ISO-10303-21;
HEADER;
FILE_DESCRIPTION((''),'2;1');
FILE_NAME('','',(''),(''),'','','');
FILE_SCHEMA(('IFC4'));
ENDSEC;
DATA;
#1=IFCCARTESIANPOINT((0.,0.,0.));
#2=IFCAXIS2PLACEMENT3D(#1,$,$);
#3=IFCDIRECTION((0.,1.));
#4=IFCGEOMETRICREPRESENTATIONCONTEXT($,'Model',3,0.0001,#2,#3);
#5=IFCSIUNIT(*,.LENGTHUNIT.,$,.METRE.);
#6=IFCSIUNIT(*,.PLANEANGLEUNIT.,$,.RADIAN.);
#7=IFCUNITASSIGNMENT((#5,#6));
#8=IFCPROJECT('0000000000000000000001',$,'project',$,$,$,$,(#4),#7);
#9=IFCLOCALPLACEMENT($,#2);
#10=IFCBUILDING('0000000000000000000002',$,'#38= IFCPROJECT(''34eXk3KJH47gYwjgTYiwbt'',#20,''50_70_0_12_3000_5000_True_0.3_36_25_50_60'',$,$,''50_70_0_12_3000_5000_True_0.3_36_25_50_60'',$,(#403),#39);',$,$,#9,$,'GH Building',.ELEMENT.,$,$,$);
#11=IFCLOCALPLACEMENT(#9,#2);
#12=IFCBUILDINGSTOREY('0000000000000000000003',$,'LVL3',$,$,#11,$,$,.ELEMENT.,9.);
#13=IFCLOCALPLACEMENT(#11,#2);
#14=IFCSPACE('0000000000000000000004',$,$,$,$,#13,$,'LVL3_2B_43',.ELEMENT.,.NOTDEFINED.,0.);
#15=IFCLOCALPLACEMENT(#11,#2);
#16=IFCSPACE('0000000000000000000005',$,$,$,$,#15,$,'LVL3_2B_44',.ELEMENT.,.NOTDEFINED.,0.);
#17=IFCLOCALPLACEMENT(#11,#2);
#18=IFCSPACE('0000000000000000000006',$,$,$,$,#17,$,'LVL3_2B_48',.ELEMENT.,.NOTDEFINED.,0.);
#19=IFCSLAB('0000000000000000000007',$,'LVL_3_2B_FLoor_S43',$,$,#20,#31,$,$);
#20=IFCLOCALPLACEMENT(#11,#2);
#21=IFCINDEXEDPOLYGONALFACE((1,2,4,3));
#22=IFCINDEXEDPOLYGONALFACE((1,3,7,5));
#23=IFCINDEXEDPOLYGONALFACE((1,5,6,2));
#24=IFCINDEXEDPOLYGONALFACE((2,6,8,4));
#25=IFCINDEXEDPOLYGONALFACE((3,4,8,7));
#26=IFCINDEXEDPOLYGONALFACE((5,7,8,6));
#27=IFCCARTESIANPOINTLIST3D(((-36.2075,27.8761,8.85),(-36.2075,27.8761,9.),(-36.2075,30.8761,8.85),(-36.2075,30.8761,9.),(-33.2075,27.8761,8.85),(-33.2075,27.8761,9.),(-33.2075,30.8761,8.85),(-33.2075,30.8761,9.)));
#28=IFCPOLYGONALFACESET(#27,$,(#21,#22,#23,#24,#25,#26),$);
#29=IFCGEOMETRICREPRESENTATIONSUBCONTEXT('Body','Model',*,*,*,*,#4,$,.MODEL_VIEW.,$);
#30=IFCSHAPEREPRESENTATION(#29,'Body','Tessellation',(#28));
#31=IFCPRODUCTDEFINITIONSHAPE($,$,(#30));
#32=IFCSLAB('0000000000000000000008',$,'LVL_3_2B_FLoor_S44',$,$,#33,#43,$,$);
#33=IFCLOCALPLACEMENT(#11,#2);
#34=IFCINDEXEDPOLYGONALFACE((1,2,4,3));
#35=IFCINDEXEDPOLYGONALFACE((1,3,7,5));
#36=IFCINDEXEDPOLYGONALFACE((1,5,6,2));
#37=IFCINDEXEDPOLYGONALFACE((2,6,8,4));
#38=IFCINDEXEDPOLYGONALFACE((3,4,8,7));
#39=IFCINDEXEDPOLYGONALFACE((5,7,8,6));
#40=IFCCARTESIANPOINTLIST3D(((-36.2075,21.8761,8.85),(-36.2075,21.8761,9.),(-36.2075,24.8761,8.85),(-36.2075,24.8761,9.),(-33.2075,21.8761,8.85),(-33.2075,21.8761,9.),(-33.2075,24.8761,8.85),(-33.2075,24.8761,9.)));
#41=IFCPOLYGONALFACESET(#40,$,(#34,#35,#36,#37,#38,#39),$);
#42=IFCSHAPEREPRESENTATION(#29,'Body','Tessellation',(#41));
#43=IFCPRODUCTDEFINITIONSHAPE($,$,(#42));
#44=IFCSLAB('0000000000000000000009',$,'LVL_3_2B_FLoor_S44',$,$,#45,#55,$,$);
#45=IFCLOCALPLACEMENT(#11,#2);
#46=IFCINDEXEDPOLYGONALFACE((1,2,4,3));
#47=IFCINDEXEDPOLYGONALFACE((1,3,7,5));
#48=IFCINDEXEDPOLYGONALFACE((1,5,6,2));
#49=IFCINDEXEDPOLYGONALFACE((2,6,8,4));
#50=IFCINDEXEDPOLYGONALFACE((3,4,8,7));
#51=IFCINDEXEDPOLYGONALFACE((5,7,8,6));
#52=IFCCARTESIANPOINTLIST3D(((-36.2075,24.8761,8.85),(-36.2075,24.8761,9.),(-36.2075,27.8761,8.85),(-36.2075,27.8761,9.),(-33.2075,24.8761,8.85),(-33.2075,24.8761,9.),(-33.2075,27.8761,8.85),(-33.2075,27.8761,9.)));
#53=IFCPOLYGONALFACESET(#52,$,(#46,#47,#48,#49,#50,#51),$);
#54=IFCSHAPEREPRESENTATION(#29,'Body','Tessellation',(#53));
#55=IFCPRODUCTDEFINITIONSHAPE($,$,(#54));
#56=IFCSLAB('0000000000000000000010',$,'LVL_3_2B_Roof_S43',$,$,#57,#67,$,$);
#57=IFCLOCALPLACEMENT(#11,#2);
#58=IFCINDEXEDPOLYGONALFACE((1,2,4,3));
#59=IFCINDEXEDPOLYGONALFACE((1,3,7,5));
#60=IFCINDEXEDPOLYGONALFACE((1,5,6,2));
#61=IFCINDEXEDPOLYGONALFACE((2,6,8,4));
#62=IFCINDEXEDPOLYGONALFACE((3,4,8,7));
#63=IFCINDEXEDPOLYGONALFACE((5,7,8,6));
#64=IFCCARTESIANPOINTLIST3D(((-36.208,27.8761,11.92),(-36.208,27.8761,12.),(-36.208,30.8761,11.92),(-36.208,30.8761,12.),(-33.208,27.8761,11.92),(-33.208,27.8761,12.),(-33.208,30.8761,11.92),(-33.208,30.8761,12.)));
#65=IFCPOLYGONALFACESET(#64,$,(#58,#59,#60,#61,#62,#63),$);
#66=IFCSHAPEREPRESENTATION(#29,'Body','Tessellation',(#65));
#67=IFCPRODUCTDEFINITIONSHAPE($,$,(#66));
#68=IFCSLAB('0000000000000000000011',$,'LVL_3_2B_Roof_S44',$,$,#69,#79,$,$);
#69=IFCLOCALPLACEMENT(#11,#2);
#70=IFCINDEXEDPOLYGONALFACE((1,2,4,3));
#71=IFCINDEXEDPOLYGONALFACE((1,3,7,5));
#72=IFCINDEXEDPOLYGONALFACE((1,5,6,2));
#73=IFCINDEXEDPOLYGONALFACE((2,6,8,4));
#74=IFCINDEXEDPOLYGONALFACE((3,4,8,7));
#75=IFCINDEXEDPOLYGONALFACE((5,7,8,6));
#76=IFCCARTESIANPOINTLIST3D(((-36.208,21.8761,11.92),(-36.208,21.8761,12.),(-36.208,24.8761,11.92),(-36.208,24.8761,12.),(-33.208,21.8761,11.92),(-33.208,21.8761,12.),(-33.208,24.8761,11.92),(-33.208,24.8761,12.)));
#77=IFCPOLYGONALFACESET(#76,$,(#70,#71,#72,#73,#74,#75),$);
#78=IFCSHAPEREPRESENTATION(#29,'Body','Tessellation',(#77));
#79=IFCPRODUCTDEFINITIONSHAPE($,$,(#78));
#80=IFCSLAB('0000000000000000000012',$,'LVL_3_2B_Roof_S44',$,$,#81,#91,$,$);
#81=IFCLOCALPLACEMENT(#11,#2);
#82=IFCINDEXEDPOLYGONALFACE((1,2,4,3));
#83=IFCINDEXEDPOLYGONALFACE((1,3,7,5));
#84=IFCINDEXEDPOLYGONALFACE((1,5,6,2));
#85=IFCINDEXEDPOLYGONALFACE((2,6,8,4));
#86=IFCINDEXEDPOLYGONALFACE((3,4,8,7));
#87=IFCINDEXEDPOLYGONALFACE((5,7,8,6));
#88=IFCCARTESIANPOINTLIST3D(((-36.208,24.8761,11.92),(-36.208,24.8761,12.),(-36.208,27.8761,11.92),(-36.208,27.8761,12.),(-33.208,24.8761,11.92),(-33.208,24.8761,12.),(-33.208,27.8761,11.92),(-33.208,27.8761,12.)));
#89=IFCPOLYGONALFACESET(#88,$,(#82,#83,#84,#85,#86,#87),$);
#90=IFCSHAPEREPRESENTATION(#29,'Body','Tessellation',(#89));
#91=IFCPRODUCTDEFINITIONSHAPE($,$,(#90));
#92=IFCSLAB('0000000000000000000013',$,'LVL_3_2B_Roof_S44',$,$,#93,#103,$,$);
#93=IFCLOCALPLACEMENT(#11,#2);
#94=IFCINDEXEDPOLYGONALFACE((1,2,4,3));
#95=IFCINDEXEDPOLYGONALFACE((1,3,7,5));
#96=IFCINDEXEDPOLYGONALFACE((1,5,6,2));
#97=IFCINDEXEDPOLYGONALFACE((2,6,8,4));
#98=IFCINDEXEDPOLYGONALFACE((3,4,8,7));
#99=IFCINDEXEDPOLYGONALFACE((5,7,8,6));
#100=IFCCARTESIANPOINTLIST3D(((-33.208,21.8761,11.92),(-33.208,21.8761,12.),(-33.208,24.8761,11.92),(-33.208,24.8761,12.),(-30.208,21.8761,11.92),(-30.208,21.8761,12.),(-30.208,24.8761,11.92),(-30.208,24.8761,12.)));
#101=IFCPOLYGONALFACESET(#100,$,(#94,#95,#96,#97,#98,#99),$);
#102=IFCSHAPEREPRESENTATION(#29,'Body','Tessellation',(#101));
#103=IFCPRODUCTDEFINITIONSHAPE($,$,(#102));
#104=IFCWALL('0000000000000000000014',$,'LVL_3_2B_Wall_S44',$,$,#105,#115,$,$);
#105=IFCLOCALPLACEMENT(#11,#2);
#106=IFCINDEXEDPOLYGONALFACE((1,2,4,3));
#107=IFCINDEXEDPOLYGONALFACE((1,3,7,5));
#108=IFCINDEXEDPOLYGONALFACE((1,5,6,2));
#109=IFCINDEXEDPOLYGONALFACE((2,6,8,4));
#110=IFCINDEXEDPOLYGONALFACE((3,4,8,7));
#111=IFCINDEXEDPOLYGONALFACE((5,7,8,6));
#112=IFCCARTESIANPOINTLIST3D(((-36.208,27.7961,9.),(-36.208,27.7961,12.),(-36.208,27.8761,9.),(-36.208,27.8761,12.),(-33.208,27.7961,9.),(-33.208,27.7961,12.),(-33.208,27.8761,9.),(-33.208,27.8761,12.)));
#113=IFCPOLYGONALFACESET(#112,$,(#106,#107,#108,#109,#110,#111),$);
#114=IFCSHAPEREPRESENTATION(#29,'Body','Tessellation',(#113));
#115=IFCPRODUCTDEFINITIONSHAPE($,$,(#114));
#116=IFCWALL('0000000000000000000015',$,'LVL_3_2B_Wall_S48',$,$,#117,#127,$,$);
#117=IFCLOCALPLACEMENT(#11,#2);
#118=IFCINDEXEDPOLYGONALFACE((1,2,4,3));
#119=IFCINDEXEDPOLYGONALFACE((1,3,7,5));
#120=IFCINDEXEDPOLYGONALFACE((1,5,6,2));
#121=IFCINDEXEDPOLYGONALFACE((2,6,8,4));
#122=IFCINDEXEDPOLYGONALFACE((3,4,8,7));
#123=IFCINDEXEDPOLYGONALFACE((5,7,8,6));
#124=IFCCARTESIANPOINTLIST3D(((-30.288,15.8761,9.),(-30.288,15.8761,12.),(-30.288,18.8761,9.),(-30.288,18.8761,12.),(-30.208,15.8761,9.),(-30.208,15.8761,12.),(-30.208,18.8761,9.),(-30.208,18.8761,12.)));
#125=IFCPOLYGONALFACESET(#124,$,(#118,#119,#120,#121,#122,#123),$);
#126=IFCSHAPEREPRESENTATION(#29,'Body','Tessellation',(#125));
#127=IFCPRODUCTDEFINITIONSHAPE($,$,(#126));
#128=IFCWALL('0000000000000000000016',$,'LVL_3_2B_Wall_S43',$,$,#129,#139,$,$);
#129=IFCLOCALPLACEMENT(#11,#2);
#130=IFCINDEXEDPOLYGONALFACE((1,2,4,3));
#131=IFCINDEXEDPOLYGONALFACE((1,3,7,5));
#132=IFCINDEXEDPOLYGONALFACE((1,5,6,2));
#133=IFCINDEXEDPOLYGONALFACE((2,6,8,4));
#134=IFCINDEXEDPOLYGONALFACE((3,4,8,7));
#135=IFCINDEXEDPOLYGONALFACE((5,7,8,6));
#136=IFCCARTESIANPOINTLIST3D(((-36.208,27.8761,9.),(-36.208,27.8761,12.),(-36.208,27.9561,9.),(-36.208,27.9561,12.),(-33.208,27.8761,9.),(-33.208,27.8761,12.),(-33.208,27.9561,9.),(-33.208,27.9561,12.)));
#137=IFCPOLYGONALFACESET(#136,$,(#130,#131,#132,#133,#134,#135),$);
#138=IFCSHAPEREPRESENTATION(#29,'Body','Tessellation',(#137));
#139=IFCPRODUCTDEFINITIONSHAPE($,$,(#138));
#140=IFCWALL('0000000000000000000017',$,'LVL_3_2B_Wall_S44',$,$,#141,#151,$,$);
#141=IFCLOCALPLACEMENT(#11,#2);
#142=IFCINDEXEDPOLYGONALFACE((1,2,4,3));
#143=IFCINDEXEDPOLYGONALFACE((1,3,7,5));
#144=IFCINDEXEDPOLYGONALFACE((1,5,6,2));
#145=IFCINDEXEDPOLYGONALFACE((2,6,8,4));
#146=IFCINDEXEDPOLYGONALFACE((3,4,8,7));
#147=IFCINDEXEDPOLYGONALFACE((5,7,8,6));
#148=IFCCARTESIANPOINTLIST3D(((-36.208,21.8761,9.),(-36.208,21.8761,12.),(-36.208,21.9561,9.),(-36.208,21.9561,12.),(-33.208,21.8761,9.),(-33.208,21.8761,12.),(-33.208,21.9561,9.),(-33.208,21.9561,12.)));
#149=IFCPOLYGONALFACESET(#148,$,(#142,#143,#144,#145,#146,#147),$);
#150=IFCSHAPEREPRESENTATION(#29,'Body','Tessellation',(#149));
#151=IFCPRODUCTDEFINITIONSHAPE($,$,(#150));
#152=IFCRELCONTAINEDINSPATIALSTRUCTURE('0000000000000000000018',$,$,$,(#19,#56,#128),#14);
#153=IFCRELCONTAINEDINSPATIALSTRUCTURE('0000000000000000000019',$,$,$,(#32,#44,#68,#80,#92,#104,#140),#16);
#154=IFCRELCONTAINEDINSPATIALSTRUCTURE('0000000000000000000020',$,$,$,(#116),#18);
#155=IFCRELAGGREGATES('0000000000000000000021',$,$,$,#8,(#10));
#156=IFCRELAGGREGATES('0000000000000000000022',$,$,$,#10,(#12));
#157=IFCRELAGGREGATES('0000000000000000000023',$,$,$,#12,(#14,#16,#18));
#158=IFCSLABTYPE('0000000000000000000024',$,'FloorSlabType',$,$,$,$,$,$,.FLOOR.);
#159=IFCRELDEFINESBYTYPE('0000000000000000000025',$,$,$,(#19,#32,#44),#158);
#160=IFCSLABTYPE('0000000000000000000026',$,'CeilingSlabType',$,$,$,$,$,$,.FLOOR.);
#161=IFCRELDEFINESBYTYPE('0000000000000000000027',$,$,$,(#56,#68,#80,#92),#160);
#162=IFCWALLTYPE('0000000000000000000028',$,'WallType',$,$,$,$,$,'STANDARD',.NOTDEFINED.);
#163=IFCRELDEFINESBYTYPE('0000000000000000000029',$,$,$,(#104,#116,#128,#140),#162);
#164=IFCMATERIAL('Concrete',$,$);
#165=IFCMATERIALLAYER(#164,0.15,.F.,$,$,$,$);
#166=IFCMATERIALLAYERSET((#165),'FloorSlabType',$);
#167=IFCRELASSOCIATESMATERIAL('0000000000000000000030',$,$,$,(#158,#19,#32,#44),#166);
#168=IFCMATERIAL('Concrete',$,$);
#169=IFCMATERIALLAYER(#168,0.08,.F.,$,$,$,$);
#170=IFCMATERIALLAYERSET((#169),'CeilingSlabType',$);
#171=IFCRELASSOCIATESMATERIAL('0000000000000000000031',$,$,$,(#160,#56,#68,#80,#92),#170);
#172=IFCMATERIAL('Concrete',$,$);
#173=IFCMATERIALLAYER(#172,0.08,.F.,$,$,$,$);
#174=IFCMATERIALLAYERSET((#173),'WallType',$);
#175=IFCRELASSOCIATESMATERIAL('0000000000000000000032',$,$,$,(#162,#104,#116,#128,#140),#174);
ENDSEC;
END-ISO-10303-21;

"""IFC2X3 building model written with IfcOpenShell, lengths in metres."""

from ifc_helpers import new_model, si_unit, direction, frame, frame_2d, origin, place, context, subcontext, project, spatial, rectangle, extrude, material, layer, layer_set, layer_usage, type_object, element, save


model = new_model("IFC2X3")

# Units and contexts
model_context = context("Model", 3, precision=0.0001, world=origin(), true_north=direction((0.0, 1.0)))
body_context = subcontext(model_context, "Body", "Model", "MODEL_VIEW")
ifc_project = project(units=[si_unit("LENGTHUNIT", "METRE"), si_unit("PLANEANGLEUNIT", "RADIAN")], contexts=[model_context])

# Building, storey, space
building_placement = place(None, origin())
building = spatial("IfcBuilding", under=ifc_project, at=building_placement, Name="#38= IFCPROJECT('34eXk3KJH47gYwjgTYiwbt',#20,'50_70_0_12_3000_5000_True_0.3_36_25_50_60',$,$,'50_70_0_12_3000_5000_True_0.3_36_25_50_60',$,(#403),#39);", LongName="GH Building", CompositionType="ELEMENT")
storey_placement = place(building_placement, origin())
storey = spatial("IfcBuildingStorey", under=building, at=storey_placement, Name="LVL3", CompositionType="ELEMENT", Elevation=9.0)
space_1_placement = place(storey_placement, origin())
space_1 = spatial("IfcSpace", under=storey, at=space_1_placement, LongName="LVL3_2B_43", CompositionType="ELEMENT", InteriorOrExteriorSpace="NOTDEFINED", ElevationWithFlooring=0.0)

# Slab
ifc_material_1 = material(Name="Concrete")
ifc_layer_1 = layer(ifc_material_1, 0.15, ventilated=False)
ifc_layer_set_1 = layer_set([ifc_layer_1], Name="FloorSlabType")
ifc_layer_usage_1 = layer_usage(ifc_layer_set_1, "AXIS3", "NEGATIVE", -0.15)
slab_type_1 = type_object("IfcSlabType", Name="FloorSlabType", PredefinedType="FLOOR", material=ifc_layer_set_1)
slab_1_placement = place(space_1_placement, frame((-33.2075, 27.8761, 8.85), z_axis=(0.0, 0.0, 1.0), x_axis=(0.0, 1.0, 0.0)))
element("IfcSlab", 1, at=slab_1_placement, inside=space_1, type_object=slab_type_1, material=ifc_layer_usage_1, Name="LVL_3_2B_FLoor_S43", context=body_context, shape_type="SweptSolid", body=[
    extrude(rectangle(XDim=3.0, YDim=3.0, at=frame_2d((1.5, 1.5))), origin(), (0.0, 0.0, 1.0), 0.15),
])

# Shared definitions
space_2_placement = place(storey_placement, origin())
space_2 = spatial("IfcSpace", under=storey, at=space_2_placement, LongName="LVL3_2B_44", CompositionType="ELEMENT", InteriorOrExteriorSpace="NOTDEFINED", ElevationWithFlooring=0.0)

# Slabs
ifc_layer_usage_2 = layer_usage(ifc_layer_set_1, "AXIS3", "NEGATIVE", -0.15)
slab_2_placement = place(space_2_placement, frame((-33.2075, 21.8761, 8.85), z_axis=(0.0, 0.0, 1.0), x_axis=(0.0, 1.0, 0.0)))
element("IfcSlab", 2, at=slab_2_placement, inside=space_2, type_object=slab_type_1, material=ifc_layer_usage_2, Name="LVL_3_2B_FLoor_S44", context=body_context, shape_type="SweptSolid", body=[
    extrude(rectangle(XDim=3.0, YDim=3.0, at=frame_2d((1.5, 1.5))), origin(), (0.0, 0.0, 1.0), 0.15),
])
ifc_layer_usage_3 = layer_usage(ifc_layer_set_1, "AXIS3", "NEGATIVE", -0.15)
slab_3_placement = place(space_2_placement, frame((-33.2075, 24.8761, 8.85), z_axis=(0.0, 0.0, 1.0), x_axis=(0.0, 1.0, 0.0)))
element("IfcSlab", 3, at=slab_3_placement, inside=space_2, type_object=slab_type_1, material=ifc_layer_usage_3, Name="LVL_3_2B_FLoor_S44", context=body_context, shape_type="SweptSolid", body=[
    extrude(rectangle(XDim=3.0, YDim=3.0, at=frame_2d((1.5, 1.5))), origin(), (0.0, 0.0, 1.0), 0.15),
])
ifc_material_2 = material(Name="Concrete")
ifc_layer_2 = layer(ifc_material_2, 0.08, ventilated=False)
ifc_layer_set_2 = layer_set([ifc_layer_2], Name="CeilingSlabType")
ifc_layer_usage_4 = layer_usage(ifc_layer_set_2, "AXIS3", "NEGATIVE", -0.08)
slab_type_2 = type_object("IfcSlabType", Name="CeilingSlabType", PredefinedType="FLOOR", material=ifc_layer_set_2)
slab_4_placement = place(space_1_placement, frame((-33.208, 27.8761, 11.92), z_axis=(0.0, 0.0, 1.0), x_axis=(0.0, 1.0, 0.0)))
element("IfcSlab", 4, at=slab_4_placement, inside=space_1, type_object=slab_type_2, material=ifc_layer_usage_4, Name="LVL_3_2B_Roof_S43", context=body_context, shape_type="SweptSolid", body=[
    extrude(rectangle(XDim=3.0, YDim=3.0, at=frame_2d((1.5, 1.5))), origin(), (0.0, 0.0, 1.0), 0.08),
])
ifc_layer_usage_5 = layer_usage(ifc_layer_set_2, "AXIS3", "NEGATIVE", -0.08)
slab_5_placement = place(space_2_placement, frame((-33.208, 21.8761, 11.92), z_axis=(0.0, 0.0, 1.0), x_axis=(0.0, 1.0, 0.0)))
element("IfcSlab", 5, at=slab_5_placement, inside=space_2, type_object=slab_type_2, material=ifc_layer_usage_5, Name="LVL_3_2B_Roof_S44", context=body_context, shape_type="SweptSolid", body=[
    extrude(rectangle(XDim=3.0, YDim=3.0, at=frame_2d((1.5, 1.5))), origin(), (0.0, 0.0, 1.0), 0.08),
])
ifc_layer_usage_6 = layer_usage(ifc_layer_set_2, "AXIS3", "NEGATIVE", -0.08)
slab_6_placement = place(space_2_placement, frame((-33.208, 24.8761, 11.92), z_axis=(0.0, 0.0, 1.0), x_axis=(0.0, 1.0, 0.0)))
element("IfcSlab", 6, at=slab_6_placement, inside=space_2, type_object=slab_type_2, material=ifc_layer_usage_6, Name="LVL_3_2B_Roof_S44", context=body_context, shape_type="SweptSolid", body=[
    extrude(rectangle(XDim=3.0, YDim=3.0, at=frame_2d((1.5, 1.5))), origin(), (0.0, 0.0, 1.0), 0.08),
])
ifc_layer_usage_7 = layer_usage(ifc_layer_set_2, "AXIS3", "NEGATIVE", -0.08)
slab_7_placement = place(space_2_placement, frame((-30.208, 21.8761, 11.92), z_axis=(0.0, 0.0, 1.0), x_axis=(0.0, 1.0, 0.0)))
element("IfcSlab", 7, at=slab_7_placement, inside=space_2, type_object=slab_type_2, material=ifc_layer_usage_7, Name="LVL_3_2B_Roof_S44", context=body_context, shape_type="SweptSolid", body=[
    extrude(rectangle(XDim=3.0, YDim=3.0, at=frame_2d((1.5, 1.5))), origin(), (0.0, 0.0, 1.0), 0.08),
])

# Shared definitions
ifc_material_3 = material(Name="Concrete")
ifc_layer_3 = layer(ifc_material_3, 0.08, ventilated=False)
ifc_layer_set_3 = layer_set([ifc_layer_3], Name="WallType")
wall_type = type_object("IfcWallType", Name="WallType", ElementType="STANDARD", PredefinedType="NOTDEFINED", material=ifc_layer_set_3)

# Shared definitions
space_3_placement = place(storey_placement, origin())
space_3 = spatial("IfcSpace", under=storey, at=space_3_placement, LongName="LVL3_2B_48", CompositionType="ELEMENT", InteriorOrExteriorSpace="NOTDEFINED", ElevationWithFlooring=0.0)

# Walls
ifc_layer_usage_8 = layer_usage(ifc_layer_set_3, "AXIS2", "NEGATIVE", 0.0)
wall_1_placement = place(space_2_placement, frame((-36.208, 27.8761, 9.0)))
element("IfcWall", 8, at=wall_1_placement, inside=space_2, type_object=wall_type, material=ifc_layer_usage_8, Name="LVL_3_2B_Wall_S44", context=body_context, shape_type="SweptSolid", body=[
    extrude(rectangle(XDim=3.0, YDim=0.08, at=frame_2d((1.5, -0.04))), origin(), (0.0, 0.0, 1.0), 3.0),
])
ifc_layer_usage_9 = layer_usage(ifc_layer_set_3, "AXIS2", "NEGATIVE", 0.0)
wall_2_placement = place(space_3_placement, frame((-30.208, 18.8761, 9.0), z_axis=(0.0, 0.0, 1.0), x_axis=(0.0, -1.0, 0.0)))
element("IfcWall", 9, at=wall_2_placement, inside=space_3, type_object=wall_type, material=ifc_layer_usage_9, Name="LVL_3_2B_Wall_S48", context=body_context, shape_type="SweptSolid", body=[
    extrude(rectangle(XDim=3.0, YDim=0.08, at=frame_2d((1.5, -0.04))), origin(), (0.0, 0.0, 1.0), 3.0),
])
ifc_layer_usage_10 = layer_usage(ifc_layer_set_3, "AXIS2", "NEGATIVE", 0.0)
wall_3_placement = place(space_1_placement, frame((-33.208, 27.8761, 9.0), z_axis=(0.0, 0.0, 1.0), x_axis=(-1.0, 0.0, 0.0)))
element("IfcWall", 10, at=wall_3_placement, inside=space_1, type_object=wall_type, material=ifc_layer_usage_10, Name="LVL_3_2B_Wall_S43", context=body_context, shape_type="SweptSolid", body=[
    extrude(rectangle(XDim=3.0, YDim=0.08, at=frame_2d((1.5, -0.04))), origin(), (0.0, 0.0, 1.0), 3.0),
])
ifc_layer_usage_11 = layer_usage(ifc_layer_set_3, "AXIS2", "NEGATIVE", 0.0)
wall_4_placement = place(space_2_placement, frame((-33.208, 21.8761, 9.0), z_axis=(0.0, 0.0, 1.0), x_axis=(-1.0, 0.0, 0.0)))
element("IfcWall", 11, at=wall_4_placement, inside=space_2, type_object=wall_type, material=ifc_layer_usage_11, Name="LVL_3_2B_Wall_S44", context=body_context, shape_type="SweptSolid", body=[
    extrude(rectangle(XDim=3.0, YDim=0.08, at=frame_2d((1.5, -0.04))), origin(), (0.0, 0.0, 1.0), 3.0),
])

save(model, "model.ifc")
